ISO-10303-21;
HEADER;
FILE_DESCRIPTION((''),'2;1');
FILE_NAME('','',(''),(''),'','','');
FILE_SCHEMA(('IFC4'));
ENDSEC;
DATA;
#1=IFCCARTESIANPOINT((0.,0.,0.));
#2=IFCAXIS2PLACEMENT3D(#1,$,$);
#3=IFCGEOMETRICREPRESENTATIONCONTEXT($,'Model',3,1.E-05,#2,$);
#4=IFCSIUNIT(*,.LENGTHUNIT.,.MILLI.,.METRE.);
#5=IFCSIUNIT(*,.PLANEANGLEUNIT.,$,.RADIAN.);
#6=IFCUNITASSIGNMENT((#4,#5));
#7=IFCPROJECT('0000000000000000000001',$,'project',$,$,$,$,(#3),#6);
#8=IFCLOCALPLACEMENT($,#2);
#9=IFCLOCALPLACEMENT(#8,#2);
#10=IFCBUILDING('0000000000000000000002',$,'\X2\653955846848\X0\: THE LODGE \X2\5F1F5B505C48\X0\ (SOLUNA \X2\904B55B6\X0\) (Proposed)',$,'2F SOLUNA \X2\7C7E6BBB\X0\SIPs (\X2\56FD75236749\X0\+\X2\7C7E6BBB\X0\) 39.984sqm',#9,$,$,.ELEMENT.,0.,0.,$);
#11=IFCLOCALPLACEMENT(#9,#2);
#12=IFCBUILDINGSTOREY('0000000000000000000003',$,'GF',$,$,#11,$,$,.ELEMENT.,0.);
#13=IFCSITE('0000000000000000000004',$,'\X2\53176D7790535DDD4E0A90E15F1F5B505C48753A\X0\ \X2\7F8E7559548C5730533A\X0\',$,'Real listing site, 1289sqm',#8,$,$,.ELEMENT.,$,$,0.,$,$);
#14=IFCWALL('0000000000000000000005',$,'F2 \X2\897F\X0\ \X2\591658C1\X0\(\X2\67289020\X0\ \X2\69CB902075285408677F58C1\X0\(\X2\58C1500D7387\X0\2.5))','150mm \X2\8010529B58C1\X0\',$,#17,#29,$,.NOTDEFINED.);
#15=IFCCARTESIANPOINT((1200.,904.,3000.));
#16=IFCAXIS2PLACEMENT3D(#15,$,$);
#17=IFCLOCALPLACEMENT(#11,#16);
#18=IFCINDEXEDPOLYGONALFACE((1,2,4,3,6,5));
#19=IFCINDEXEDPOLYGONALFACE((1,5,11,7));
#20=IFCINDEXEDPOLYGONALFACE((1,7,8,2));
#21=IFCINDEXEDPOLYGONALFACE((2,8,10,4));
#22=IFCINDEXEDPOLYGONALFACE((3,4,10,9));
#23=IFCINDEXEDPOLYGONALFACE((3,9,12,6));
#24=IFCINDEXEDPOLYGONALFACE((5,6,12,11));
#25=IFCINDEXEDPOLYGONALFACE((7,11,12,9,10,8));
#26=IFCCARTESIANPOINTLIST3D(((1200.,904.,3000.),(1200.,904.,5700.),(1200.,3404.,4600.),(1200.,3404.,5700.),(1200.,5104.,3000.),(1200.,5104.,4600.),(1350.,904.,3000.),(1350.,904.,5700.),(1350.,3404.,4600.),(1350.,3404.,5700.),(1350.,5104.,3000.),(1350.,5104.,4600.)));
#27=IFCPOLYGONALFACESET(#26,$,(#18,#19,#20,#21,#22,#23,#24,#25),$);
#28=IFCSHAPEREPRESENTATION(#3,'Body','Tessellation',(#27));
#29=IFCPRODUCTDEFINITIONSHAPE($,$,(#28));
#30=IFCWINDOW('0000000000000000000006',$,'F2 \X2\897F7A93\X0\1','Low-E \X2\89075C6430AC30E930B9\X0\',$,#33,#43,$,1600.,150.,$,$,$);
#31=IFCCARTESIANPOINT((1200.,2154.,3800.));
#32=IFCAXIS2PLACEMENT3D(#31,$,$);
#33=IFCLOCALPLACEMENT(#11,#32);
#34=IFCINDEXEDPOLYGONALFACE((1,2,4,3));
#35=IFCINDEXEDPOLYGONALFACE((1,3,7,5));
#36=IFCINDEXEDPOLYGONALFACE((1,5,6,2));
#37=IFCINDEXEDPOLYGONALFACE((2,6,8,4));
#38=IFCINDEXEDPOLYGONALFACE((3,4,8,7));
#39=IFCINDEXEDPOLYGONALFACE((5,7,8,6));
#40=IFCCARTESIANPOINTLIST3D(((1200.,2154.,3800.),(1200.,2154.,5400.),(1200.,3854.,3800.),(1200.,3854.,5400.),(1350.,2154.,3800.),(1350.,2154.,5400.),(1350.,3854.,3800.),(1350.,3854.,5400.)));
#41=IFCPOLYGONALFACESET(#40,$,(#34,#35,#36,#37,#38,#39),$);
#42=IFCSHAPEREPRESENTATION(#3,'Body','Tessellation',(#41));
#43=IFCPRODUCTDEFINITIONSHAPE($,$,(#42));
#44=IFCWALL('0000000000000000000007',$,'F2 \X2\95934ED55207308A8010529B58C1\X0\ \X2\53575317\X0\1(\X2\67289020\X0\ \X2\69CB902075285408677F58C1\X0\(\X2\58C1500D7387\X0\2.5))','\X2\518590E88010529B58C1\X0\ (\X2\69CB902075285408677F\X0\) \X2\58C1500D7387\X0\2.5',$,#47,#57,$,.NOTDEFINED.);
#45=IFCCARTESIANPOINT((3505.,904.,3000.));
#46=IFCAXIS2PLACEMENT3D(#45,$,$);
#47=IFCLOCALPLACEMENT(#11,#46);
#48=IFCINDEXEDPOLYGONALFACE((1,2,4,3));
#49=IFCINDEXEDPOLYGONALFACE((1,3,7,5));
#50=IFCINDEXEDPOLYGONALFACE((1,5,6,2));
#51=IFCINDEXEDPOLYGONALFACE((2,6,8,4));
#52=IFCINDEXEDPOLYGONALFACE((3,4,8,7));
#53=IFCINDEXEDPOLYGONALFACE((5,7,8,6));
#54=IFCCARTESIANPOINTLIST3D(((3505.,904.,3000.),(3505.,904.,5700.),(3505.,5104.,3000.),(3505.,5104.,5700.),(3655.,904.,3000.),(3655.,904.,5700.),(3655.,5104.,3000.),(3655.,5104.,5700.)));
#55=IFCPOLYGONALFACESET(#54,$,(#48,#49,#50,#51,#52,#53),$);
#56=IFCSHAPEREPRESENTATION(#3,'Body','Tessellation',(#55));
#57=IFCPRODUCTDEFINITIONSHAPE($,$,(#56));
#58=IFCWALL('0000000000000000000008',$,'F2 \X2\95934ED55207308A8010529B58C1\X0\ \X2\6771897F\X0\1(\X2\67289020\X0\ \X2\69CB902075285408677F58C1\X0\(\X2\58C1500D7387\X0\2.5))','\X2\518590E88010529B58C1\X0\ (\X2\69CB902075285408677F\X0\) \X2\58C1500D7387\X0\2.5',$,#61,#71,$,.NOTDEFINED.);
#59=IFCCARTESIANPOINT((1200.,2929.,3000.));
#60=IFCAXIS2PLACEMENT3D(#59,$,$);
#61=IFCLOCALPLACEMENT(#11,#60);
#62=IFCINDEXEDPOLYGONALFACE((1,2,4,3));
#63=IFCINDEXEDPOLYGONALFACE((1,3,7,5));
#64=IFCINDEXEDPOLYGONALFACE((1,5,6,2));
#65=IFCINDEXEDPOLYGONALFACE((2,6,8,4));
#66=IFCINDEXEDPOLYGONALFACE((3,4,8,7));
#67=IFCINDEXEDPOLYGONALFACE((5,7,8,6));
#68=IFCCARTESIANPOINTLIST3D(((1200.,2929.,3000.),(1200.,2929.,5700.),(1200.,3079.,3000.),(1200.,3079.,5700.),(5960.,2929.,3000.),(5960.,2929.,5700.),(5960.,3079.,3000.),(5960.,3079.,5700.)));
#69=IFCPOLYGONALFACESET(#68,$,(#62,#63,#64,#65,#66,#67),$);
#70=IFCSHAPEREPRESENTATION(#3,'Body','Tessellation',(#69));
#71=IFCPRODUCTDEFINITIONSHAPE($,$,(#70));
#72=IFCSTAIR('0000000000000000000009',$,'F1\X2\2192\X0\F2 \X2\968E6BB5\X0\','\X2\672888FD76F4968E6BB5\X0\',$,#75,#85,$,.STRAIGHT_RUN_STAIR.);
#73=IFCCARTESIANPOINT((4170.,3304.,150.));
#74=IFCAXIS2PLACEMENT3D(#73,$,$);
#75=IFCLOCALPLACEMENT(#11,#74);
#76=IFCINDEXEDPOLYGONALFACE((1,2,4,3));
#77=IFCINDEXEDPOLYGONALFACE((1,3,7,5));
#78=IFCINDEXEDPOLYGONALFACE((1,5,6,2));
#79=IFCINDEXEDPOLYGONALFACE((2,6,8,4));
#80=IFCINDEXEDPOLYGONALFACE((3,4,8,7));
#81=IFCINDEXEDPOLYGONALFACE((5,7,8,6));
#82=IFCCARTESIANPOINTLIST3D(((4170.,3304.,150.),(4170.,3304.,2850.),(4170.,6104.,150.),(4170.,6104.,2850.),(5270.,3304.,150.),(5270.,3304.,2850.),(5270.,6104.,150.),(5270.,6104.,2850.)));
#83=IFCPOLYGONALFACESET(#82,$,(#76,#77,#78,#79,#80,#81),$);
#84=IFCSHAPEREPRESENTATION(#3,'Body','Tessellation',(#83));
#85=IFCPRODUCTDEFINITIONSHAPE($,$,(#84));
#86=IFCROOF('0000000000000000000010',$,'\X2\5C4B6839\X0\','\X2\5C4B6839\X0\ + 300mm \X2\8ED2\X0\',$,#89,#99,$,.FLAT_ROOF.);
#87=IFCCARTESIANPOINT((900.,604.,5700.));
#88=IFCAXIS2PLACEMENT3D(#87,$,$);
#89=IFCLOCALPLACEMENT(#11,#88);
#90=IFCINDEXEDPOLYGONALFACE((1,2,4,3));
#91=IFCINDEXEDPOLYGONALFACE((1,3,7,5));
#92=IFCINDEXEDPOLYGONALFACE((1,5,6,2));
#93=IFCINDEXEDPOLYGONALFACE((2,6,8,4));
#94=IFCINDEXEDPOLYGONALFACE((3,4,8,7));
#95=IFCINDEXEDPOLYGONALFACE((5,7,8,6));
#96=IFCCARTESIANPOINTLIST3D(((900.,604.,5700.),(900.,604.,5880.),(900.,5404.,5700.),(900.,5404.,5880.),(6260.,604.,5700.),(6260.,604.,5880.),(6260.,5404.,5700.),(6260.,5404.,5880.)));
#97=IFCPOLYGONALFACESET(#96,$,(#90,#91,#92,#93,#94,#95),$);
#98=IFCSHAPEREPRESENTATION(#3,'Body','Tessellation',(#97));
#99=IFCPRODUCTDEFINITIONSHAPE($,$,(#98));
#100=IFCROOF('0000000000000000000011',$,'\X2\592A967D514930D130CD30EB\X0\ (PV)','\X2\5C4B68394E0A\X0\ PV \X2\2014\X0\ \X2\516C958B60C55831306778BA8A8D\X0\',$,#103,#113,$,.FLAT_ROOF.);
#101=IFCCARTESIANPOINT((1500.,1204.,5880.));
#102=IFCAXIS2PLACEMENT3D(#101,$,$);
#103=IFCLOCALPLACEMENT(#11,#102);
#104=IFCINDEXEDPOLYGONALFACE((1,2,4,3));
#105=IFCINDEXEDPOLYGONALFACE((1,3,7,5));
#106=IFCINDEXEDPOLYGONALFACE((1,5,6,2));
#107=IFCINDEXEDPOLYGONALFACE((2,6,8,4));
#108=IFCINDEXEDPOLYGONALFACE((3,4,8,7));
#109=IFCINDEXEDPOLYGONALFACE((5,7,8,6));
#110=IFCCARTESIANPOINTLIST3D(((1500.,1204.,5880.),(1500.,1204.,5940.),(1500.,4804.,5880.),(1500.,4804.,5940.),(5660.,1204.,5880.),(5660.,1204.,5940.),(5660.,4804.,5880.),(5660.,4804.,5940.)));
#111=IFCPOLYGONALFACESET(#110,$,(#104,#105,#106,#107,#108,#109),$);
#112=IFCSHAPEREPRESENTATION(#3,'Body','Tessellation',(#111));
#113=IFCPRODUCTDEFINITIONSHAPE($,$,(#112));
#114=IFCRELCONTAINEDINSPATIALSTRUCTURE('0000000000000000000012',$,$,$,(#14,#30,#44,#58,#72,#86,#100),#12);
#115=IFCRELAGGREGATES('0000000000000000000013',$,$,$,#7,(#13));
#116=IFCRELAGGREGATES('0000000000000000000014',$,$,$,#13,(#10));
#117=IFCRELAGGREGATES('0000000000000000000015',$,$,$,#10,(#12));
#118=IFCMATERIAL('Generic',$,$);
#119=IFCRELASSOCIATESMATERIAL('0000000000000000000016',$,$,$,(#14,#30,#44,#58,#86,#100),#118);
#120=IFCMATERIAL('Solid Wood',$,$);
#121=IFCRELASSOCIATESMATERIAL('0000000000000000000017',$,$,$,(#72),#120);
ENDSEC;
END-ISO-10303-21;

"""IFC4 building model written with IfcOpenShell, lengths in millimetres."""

from ifc_helpers import new_model, si_unit, frame, frame_2d, origin, place, context, project, spatial, rectangle, extrude, material, element, fill, save


model = new_model("IFC4")

# Units and contexts
model_context = context("Model", 3, precision=1e-05, world=origin())
ifc_project = project(units=[si_unit("LENGTHUNIT", "METRE", prefix="MILLI"), si_unit("PLANEANGLEUNIT", "RADIAN")], contexts=[model_context])

# Site, building, storey
site_placement = place(None, origin())
site = spatial("IfcSite", under=ifc_project, at=site_placement, Name="北海道川上郡弟子屈町 美留和地区", ObjectType="Real listing site, 1289sqm", CompositionType="ELEMENT", RefElevation=0.0)
building_placement = place(site_placement, origin())
building = spatial("IfcBuilding", under=site, at=building_placement, Name="改善案: THE LODGE 弟子屈 (SOLUNA 運営) (Proposed)", ObjectType="2F SOLUNA 籾殻SIPs (国産杉+籾殻) 39.984sqm", CompositionType="ELEMENT", ElevationOfRefHeight=0.0, ElevationOfTerrain=0.0)
storey_placement = place(building_placement, origin())
storey = spatial("IfcBuildingStorey", under=building, at=storey_placement, Name="GF", CompositionType="ELEMENT", Elevation=0.0)

# Shared definitions
ifc_material_1 = material(Name="Generic")

# Shared definitions
ifc_material_2 = material(Name="Solid Wood")

# Wall, opening, window
wall_1_placement = place(storey_placement, frame((1200.0, 904.0, 3000.0)))
wall_1 = element("IfcWall", 1, at=wall_1_placement, inside=storey, material=ifc_material_1, Name="F2 西 外壁(木造 構造用合板壁(壁倍率2.5))", Description="150mm 耐力壁", PredefinedType="NOTDEFINED", context=model_context, shape_type="SweptSolid", body=[
    extrude(rectangle(XDim=150.0, YDim=4200.0, at=frame_2d((75.0, 2100.0))), frame((1200.0, 904.0, 3000.0)), (0.0, 0.0, 1.0), 2700.0),
])
opening_1_placement = place(storey_placement, frame((1200.0, 2154.0, 3800.0)))
opening_1 = element("IfcOpeningElement", 2, at=opening_1_placement, cuts=wall_1, PredefinedType="NOTDEFINED", context=model_context, shape_type="SweptSolid", body=[
    extrude(rectangle(XDim=150.0, YDim=1700.0, at=frame_2d((75.0, 850.0))), frame((1200.0, 2154.0, 3800.0)), (0.0, 0.0, 1.0), 1600.0),
])
window_1_placement = place(storey_placement, frame((1200.0, 2154.0, 3800.0)))
window_1 = element("IfcWindow", 3, at=window_1_placement, inside=storey, material=ifc_material_1, Name="F2 西窓1", Description="Low-E 複層ガラス", OverallHeight=1600.0, OverallWidth=150.0, context=model_context, shape_type="SweptSolid", body=[
    extrude(rectangle(XDim=150.0, YDim=1700.0, at=frame_2d((75.0, 850.0))), frame((1200.0, 2154.0, 3800.0)), (0.0, 0.0, 1.0), 1600.0),
])
fill(opening_1, window_1)

# Walls
wall_2_placement = place(storey_placement, frame((3505.0, 904.0, 3000.0)))
element("IfcWall", 4, at=wall_2_placement, inside=storey, material=ifc_material_1, Name="F2 間仕切り耐力壁 南北1(木造 構造用合板壁(壁倍率2.5))", Description="内部耐力壁 (構造用合板) 壁倍率2.5", PredefinedType="NOTDEFINED", context=model_context, shape_type="SweptSolid", body=[
    extrude(rectangle(XDim=150.0, YDim=4200.0, at=frame_2d((75.0, 2100.0))), frame((3505.0, 904.0, 3000.0)), (0.0, 0.0, 1.0), 2700.0),
])
wall_3_placement = place(storey_placement, frame((1200.0, 2929.0, 3000.0)))
element("IfcWall", 5, at=wall_3_placement, inside=storey, material=ifc_material_1, Name="F2 間仕切り耐力壁 東西1(木造 構造用合板壁(壁倍率2.5))", Description="内部耐力壁 (構造用合板) 壁倍率2.5", PredefinedType="NOTDEFINED", context=model_context, shape_type="SweptSolid", body=[
    extrude(rectangle(XDim=4760.0, YDim=150.0, at=frame_2d((2380.0, 75.0))), frame((1200.0, 2929.0, 3000.0)), (0.0, 0.0, 1.0), 2700.0),
])

# Stair
stair_placement = place(storey_placement, frame((4170.0, 3304.0, 150.0)))
element("IfcStair", 6, at=stair_placement, inside=storey, material=ifc_material_2, Name="F1→F2 階段", Description="木製直階段", PredefinedType="STRAIGHT_RUN_STAIR", context=model_context, shape_type="SweptSolid", body=[
    extrude(rectangle(XDim=1100.0, YDim=2800.0, at=frame_2d((550.0, 1400.0))), frame((4170.0, 3304.0, 150.0)), (0.0, 0.0, 1.0), 2700.0),
])

# Roofs
roof_1_placement = place(storey_placement, frame((900.0, 604.0, 5700.0)))
element("IfcRoof", 7, at=roof_1_placement, inside=storey, material=ifc_material_1, Name="屋根", Description="屋根 + 300mm 軒", PredefinedType="FLAT_ROOF", context=model_context, shape_type="SweptSolid", body=[
    extrude(rectangle(XDim=5360.0, YDim=4800.0, at=frame_2d((2680.0, 2400.0))), frame((900.0, 604.0, 5700.0)), (0.0, 0.0, 1.0), 180.0),
])
roof_2_placement = place(storey_placement, frame((1500.0, 1204.0, 5880.0)))
element("IfcRoof", 8, at=roof_2_placement, inside=storey, material=ifc_material_1, Name="太陽光パネル (PV)", Description="屋根上 PV — 公開情報で確認", PredefinedType="FLAT_ROOF", context=model_context, shape_type="SweptSolid", body=[
    extrude(rectangle(XDim=4160.0, YDim=3600.0, at=frame_2d((2080.0, 1800.0))), frame((1500.0, 1204.0, 5880.0)), (0.0, 0.0, 1.0), 60.0),
])

save(model, "model.ifc")
